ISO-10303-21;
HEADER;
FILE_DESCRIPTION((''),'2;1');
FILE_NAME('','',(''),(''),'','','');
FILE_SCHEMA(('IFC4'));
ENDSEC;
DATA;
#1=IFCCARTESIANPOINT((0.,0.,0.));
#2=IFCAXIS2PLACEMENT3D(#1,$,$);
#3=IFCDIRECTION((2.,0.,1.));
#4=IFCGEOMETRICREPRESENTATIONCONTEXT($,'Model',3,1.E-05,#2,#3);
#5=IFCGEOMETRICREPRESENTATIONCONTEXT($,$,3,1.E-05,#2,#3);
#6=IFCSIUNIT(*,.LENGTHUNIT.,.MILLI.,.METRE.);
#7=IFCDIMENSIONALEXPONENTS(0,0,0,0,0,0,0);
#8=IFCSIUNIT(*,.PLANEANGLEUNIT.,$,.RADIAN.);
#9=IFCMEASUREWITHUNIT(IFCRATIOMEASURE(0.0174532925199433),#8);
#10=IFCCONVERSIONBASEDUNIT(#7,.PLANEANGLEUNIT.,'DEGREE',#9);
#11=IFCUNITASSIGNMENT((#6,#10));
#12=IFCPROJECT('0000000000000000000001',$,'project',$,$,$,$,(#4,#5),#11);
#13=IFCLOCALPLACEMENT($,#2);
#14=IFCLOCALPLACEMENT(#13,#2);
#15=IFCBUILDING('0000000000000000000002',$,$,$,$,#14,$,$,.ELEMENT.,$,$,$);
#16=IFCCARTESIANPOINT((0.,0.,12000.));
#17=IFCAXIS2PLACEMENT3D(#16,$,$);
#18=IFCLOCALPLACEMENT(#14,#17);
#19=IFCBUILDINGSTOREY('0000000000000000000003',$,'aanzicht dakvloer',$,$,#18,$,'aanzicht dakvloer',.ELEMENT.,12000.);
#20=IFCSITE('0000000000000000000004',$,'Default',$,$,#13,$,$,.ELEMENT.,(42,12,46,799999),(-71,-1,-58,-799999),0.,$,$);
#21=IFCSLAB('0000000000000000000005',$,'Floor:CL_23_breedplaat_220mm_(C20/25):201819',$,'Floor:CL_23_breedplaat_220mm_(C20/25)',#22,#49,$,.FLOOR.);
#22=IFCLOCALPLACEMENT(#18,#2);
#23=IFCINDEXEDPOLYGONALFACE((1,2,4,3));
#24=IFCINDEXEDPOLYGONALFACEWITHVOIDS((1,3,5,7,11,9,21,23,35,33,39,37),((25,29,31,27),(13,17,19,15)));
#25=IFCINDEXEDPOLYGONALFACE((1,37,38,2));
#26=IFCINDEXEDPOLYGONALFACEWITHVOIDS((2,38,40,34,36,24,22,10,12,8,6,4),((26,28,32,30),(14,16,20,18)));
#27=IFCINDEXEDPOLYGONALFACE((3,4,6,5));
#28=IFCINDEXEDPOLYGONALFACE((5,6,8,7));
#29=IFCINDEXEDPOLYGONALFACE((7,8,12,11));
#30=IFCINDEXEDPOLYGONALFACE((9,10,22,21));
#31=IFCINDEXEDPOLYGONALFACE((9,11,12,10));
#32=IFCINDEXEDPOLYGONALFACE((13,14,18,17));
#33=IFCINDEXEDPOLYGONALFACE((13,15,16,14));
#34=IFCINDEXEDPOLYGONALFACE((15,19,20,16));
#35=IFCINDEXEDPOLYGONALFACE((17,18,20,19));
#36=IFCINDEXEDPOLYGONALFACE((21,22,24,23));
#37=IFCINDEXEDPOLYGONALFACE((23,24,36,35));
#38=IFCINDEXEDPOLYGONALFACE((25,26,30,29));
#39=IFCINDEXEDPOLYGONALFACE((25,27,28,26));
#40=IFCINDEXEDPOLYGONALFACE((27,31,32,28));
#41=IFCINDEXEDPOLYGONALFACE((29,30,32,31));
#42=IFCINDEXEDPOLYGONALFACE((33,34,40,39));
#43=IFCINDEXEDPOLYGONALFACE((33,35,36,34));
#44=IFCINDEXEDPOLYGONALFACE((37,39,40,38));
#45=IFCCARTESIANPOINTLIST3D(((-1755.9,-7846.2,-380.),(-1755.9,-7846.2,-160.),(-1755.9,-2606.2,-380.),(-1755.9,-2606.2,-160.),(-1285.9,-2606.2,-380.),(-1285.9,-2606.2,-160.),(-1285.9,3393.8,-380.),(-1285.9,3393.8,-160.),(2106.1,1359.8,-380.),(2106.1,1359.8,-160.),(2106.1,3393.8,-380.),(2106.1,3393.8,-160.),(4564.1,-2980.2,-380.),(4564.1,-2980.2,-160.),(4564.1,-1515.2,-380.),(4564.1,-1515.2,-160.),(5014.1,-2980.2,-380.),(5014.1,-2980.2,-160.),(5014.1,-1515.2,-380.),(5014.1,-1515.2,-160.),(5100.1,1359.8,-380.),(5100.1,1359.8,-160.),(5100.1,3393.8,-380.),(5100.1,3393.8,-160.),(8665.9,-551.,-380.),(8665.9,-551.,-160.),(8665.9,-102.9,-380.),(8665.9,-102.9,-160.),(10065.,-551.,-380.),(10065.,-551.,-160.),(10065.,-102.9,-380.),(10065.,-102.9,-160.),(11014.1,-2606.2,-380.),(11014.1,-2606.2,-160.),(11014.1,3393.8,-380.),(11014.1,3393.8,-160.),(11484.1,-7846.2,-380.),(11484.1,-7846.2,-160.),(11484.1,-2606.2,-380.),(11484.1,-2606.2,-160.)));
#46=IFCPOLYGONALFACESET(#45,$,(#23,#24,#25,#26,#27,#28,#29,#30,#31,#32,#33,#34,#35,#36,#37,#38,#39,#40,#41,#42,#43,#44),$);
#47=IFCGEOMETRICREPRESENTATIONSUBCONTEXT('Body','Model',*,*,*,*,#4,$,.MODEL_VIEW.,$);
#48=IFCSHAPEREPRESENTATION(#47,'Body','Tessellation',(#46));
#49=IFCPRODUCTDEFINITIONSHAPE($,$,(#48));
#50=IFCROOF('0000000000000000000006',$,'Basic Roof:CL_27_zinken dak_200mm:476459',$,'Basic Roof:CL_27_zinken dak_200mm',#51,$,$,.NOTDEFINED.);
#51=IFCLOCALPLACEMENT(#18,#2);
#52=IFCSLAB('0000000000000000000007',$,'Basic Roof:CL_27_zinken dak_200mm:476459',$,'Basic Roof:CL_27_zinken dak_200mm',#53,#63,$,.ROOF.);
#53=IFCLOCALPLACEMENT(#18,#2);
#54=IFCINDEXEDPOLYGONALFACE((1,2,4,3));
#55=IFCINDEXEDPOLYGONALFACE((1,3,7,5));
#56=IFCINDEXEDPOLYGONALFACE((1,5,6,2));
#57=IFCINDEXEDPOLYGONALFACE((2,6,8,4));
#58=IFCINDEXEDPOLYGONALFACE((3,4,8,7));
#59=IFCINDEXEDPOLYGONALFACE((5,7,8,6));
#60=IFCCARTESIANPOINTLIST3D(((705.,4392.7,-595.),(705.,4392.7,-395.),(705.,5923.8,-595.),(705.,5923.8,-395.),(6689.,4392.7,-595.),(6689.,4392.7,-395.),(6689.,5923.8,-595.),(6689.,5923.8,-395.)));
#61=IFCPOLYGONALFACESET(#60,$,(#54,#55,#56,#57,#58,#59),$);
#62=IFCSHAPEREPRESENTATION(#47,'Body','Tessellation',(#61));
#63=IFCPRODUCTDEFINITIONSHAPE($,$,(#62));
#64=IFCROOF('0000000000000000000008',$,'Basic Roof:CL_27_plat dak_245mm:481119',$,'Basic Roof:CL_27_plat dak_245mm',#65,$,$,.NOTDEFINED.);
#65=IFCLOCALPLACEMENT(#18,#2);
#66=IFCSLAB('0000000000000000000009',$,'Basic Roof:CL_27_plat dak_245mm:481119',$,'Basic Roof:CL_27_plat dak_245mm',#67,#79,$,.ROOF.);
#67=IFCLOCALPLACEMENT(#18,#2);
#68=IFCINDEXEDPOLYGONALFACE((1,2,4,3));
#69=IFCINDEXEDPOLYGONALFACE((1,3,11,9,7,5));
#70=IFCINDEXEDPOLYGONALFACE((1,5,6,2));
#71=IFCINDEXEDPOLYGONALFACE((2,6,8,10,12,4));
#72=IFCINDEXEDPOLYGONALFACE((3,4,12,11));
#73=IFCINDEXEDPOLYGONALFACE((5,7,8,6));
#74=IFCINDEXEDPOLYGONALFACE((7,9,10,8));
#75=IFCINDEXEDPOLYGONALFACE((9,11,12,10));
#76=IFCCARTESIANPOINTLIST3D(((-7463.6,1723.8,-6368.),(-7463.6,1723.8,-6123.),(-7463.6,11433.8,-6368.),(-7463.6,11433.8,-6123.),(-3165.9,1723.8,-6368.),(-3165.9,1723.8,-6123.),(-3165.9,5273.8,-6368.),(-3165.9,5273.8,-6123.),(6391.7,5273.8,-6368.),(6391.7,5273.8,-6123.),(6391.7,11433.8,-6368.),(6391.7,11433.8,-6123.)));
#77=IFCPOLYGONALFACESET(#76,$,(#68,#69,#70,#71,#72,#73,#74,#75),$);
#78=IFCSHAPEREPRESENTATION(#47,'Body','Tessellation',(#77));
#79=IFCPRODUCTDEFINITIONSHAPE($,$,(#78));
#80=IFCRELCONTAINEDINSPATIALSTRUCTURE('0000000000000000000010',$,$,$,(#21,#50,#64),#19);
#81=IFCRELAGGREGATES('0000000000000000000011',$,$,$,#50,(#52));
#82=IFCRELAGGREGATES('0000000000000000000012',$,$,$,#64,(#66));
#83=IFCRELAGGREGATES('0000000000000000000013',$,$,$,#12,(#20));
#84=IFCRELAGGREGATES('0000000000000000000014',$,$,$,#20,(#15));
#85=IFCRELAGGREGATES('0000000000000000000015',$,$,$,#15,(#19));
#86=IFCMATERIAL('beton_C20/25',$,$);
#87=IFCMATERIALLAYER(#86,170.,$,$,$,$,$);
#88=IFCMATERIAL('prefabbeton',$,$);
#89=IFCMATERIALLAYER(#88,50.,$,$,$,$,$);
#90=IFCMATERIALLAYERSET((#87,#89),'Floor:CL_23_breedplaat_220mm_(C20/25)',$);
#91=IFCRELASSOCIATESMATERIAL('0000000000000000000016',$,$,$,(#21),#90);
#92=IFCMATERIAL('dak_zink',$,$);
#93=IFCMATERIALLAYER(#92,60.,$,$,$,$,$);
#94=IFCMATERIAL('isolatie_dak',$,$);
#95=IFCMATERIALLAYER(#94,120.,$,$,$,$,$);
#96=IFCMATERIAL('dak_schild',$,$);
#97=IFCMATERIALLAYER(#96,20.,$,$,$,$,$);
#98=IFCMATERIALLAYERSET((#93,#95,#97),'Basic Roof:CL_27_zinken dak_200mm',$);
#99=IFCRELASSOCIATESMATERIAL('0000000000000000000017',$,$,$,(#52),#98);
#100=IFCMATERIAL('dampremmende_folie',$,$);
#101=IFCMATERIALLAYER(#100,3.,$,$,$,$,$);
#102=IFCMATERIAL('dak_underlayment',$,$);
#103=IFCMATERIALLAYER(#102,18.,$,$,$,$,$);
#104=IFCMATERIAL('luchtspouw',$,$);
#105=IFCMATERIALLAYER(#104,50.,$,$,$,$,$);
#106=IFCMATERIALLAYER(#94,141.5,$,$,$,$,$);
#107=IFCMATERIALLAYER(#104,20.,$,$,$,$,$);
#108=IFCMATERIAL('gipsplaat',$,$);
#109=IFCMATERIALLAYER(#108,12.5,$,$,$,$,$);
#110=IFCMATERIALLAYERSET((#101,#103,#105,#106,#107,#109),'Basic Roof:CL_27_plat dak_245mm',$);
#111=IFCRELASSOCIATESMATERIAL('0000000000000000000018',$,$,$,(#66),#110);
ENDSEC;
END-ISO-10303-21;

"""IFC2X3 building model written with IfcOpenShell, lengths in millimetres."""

from ifc_helpers import new_model, entity, si_unit, converted_unit, direction, frame, frame_2d, origin, origin_2d_with_axis, place, context, subcontext, project, spatial, polyline, rectangle, outline, extrude, material, layer, layer_set, layer_usage, element, aggregate, save


model = new_model("IFC2X3")

# Units and contexts
model_context = context("Model", 3, precision=1e-05, world=origin(), true_north=direction((2.0, 0.0, 1.0)))
context_of_model = context(None, 3, precision=1e-05, world=origin(), true_north=direction((2.0, 0.0, 1.0)))
body_context = subcontext(model_context, "Body", "Model", "MODEL_VIEW")
ifc_project = project(units=[si_unit("LENGTHUNIT", "METRE", prefix="MILLI"), converted_unit("PLANEANGLEUNIT", "DEGREE", entity("IfcRatioMeasure", 0.0174532925199433), si_unit("PLANEANGLEUNIT", "RADIAN"), dimensions=[0, 0, 0, 0, 0, 0, 0])], contexts=[model_context, context_of_model])

# Site, building, storey
site_placement = place(None, origin())
site = spatial("IfcSite", under=ifc_project, at=site_placement, Name="Default", CompositionType="ELEMENT", RefLatitude=(42, 12, 46, 799999), RefLongitude=(-71, -1, -58, -799999), RefElevation=0.0)
building_placement = place(site_placement, origin())
building = spatial("IfcBuilding", under=site, at=building_placement, CompositionType="ELEMENT")
storey_placement = place(building_placement, frame((0.0, 0.0, 12000.0)))
storey = spatial("IfcBuildingStorey", under=building, at=storey_placement, Name="aanzicht dakvloer", LongName="aanzicht dakvloer", CompositionType="ELEMENT", Elevation=12000.0)

# Slab, openings
ifc_material_1 = material(Name="beton_C20/25")
ifc_layer_1 = layer(ifc_material_1, 170.0)
ifc_material_2 = material(Name="prefabbeton")
ifc_layer_2 = layer(ifc_material_2, 50.0)
ifc_layer_set_1 = layer_set([ifc_layer_1, ifc_layer_2], Name="Floor:CL_23_breedplaat_220mm_(C20/25)")
ifc_layer_usage = layer_usage(ifc_layer_set_1, "AXIS3", "POSITIVE", 0.0)
slab_1_placement = place(storey_placement, frame((-1755.9, -7846.2, -380.0)))
slab_1 = element("IfcSlab", 1, at=slab_1_placement, inside=storey, material=ifc_layer_usage, Name="Floor:CL_23_breedplaat_220mm_(C20/25):201819", ObjectType="Floor:CL_23_breedplaat_220mm_(C20/25)", PredefinedType="FLOOR", context=body_context, shape_type="SweptSolid", body=[
    extrude(outline(polyline([(2758.0, 5620.0), (2758.0, 3586.0), (-236.0, 3586.0), (-236.0, 5620.0), (-6150.0, 5620.0), (-6150.0, -380.0), (-6620.0, -380.0), (-6620.0, -5620.0), (6620.0, -5620.0), (6620.0, -380.0), (6150.0, -380.0), (6150.0, 5620.0), (2758.0, 5620.0)])), frame((6620.0, 5620.0, 220.0), z_axis=(0.0, 0.0, -1.0), x_axis=(-1.0, 0.0, 0.0)), (0.0, 0.0, 1.0), 220.0),
])
opening_1_placement = place(slab_1_placement, frame((11121.4, 7519.3, 220.0)))
element("IfcOpeningElement", 2, at=opening_1_placement, cuts=slab_1, ObjectType="Opening", context=body_context, shape_type="SweptSolid", body=[
    extrude(rectangle(XDim=448.1, YDim=1399.0, at=origin_2d_with_axis()), frame((0.0, 0.0, 0.0), z_axis=(0.0, 0.0, -1.0), x_axis=(0.0, -1.0, 0.0)), (0.0, 0.0, 1.0), 220.0),
])
opening_2_placement = place(slab_1_placement, frame((6545.0, 5598.5, 220.0)))
element("IfcOpeningElement", 3, at=opening_2_placement, cuts=slab_1, ObjectType="Opening", context=body_context, shape_type="SweptSolid", body=[
    extrude(rectangle(XDim=1465.0, YDim=450.0, at=origin_2d_with_axis()), frame((0.0, 0.0, 0.0), z_axis=(0.0, 0.0, -1.0), x_axis=(0.0, -1.0, 0.0)), (0.0, 0.0, 1.0), 220.0),
])

# Roofs, slabs
roof_1_placement = place(storey_placement, frame((705.0, 4392.7, -595.0)))
roof_1 = element("IfcRoof", 4, at=roof_1_placement, inside=storey, Name="Basic Roof:CL_27_zinken dak_200mm:476459", ObjectType="Basic Roof:CL_27_zinken dak_200mm", ShapeType="NOTDEFINED")
ifc_material_3 = material(Name="dak_zink")
ifc_layer_3 = layer(ifc_material_3, 60.0)
ifc_material_4 = material(Name="isolatie_dak")
ifc_layer_4 = layer(ifc_material_4, 120.0)
ifc_material_5 = material(Name="dak_schild")
ifc_layer_5 = layer(ifc_material_5, 20.0)
ifc_layer_set_2 = layer_set([ifc_layer_3, ifc_layer_4, ifc_layer_5], Name="Basic Roof:CL_27_zinken dak_200mm")
slab_2_placement = place(roof_1_placement, origin())
slab_2 = element("IfcSlab", 5, at=slab_2_placement, material=ifc_layer_set_2, Name="Basic Roof:CL_27_zinken dak_200mm:476459", ObjectType="Basic Roof:CL_27_zinken dak_200mm", PredefinedType="ROOF", context=body_context, shape_type="SweptSolid", body=[
    extrude(rectangle(XDim=5984.0, YDim=1531.1, at=frame_2d((0.0, 0.0), x_axis=(1.0, 0.0))), frame((2992.0, 765.5, 0.0)), (0.0, 0.0, 1.0), 200.0),
])
aggregate(roof_1, [slab_2])
roof_2_placement = place(storey_placement, frame((-7463.6, 1723.8, -6368.0)))
roof_2 = element("IfcRoof", 6, at=roof_2_placement, inside=storey, Name="Basic Roof:CL_27_plat dak_245mm:481119", ObjectType="Basic Roof:CL_27_plat dak_245mm", ShapeType="NOTDEFINED")
ifc_material_6 = material(Name="dampremmende_folie")
ifc_layer_6 = layer(ifc_material_6, 3.0)
ifc_material_7 = material(Name="dak_underlayment")
ifc_layer_7 = layer(ifc_material_7, 18.0)
ifc_material_8 = material(Name="luchtspouw")
ifc_layer_8 = layer(ifc_material_8, 50.0)
ifc_layer_9 = layer(ifc_material_4, 141.5)
ifc_layer_10 = layer(ifc_material_8, 20.0)
ifc_material_9 = material(Name="gipsplaat")
ifc_layer_11 = layer(ifc_material_9, 12.5)
ifc_layer_set_3 = layer_set([ifc_layer_6, ifc_layer_7, ifc_layer_8, ifc_layer_9, ifc_layer_10, ifc_layer_11], Name="Basic Roof:CL_27_plat dak_245mm")
slab_3_placement = place(roof_2_placement, origin())
slab_3 = element("IfcSlab", 7, at=slab_3_placement, material=ifc_layer_set_3, Name="Basic Roof:CL_27_plat dak_245mm:481119", ObjectType="Basic Roof:CL_27_plat dak_245mm", PredefinedType="ROOF", context=body_context, shape_type="SweptSolid", body=[
    extrude(outline(polyline([(-6927.7, 4855.0), (-6927.7, -4855.0), (-2630.0, -4855.0), (-2630.0, -1305.0), (6927.7, -1305.0), (6927.7, 4855.0), (-6927.7, 4855.0)])), frame((6927.7, 4855.0, 0.0)), (0.0, 0.0, 1.0), 245.0),
])
aggregate(roof_2, [slab_3])

save(model, "model.ifc")
